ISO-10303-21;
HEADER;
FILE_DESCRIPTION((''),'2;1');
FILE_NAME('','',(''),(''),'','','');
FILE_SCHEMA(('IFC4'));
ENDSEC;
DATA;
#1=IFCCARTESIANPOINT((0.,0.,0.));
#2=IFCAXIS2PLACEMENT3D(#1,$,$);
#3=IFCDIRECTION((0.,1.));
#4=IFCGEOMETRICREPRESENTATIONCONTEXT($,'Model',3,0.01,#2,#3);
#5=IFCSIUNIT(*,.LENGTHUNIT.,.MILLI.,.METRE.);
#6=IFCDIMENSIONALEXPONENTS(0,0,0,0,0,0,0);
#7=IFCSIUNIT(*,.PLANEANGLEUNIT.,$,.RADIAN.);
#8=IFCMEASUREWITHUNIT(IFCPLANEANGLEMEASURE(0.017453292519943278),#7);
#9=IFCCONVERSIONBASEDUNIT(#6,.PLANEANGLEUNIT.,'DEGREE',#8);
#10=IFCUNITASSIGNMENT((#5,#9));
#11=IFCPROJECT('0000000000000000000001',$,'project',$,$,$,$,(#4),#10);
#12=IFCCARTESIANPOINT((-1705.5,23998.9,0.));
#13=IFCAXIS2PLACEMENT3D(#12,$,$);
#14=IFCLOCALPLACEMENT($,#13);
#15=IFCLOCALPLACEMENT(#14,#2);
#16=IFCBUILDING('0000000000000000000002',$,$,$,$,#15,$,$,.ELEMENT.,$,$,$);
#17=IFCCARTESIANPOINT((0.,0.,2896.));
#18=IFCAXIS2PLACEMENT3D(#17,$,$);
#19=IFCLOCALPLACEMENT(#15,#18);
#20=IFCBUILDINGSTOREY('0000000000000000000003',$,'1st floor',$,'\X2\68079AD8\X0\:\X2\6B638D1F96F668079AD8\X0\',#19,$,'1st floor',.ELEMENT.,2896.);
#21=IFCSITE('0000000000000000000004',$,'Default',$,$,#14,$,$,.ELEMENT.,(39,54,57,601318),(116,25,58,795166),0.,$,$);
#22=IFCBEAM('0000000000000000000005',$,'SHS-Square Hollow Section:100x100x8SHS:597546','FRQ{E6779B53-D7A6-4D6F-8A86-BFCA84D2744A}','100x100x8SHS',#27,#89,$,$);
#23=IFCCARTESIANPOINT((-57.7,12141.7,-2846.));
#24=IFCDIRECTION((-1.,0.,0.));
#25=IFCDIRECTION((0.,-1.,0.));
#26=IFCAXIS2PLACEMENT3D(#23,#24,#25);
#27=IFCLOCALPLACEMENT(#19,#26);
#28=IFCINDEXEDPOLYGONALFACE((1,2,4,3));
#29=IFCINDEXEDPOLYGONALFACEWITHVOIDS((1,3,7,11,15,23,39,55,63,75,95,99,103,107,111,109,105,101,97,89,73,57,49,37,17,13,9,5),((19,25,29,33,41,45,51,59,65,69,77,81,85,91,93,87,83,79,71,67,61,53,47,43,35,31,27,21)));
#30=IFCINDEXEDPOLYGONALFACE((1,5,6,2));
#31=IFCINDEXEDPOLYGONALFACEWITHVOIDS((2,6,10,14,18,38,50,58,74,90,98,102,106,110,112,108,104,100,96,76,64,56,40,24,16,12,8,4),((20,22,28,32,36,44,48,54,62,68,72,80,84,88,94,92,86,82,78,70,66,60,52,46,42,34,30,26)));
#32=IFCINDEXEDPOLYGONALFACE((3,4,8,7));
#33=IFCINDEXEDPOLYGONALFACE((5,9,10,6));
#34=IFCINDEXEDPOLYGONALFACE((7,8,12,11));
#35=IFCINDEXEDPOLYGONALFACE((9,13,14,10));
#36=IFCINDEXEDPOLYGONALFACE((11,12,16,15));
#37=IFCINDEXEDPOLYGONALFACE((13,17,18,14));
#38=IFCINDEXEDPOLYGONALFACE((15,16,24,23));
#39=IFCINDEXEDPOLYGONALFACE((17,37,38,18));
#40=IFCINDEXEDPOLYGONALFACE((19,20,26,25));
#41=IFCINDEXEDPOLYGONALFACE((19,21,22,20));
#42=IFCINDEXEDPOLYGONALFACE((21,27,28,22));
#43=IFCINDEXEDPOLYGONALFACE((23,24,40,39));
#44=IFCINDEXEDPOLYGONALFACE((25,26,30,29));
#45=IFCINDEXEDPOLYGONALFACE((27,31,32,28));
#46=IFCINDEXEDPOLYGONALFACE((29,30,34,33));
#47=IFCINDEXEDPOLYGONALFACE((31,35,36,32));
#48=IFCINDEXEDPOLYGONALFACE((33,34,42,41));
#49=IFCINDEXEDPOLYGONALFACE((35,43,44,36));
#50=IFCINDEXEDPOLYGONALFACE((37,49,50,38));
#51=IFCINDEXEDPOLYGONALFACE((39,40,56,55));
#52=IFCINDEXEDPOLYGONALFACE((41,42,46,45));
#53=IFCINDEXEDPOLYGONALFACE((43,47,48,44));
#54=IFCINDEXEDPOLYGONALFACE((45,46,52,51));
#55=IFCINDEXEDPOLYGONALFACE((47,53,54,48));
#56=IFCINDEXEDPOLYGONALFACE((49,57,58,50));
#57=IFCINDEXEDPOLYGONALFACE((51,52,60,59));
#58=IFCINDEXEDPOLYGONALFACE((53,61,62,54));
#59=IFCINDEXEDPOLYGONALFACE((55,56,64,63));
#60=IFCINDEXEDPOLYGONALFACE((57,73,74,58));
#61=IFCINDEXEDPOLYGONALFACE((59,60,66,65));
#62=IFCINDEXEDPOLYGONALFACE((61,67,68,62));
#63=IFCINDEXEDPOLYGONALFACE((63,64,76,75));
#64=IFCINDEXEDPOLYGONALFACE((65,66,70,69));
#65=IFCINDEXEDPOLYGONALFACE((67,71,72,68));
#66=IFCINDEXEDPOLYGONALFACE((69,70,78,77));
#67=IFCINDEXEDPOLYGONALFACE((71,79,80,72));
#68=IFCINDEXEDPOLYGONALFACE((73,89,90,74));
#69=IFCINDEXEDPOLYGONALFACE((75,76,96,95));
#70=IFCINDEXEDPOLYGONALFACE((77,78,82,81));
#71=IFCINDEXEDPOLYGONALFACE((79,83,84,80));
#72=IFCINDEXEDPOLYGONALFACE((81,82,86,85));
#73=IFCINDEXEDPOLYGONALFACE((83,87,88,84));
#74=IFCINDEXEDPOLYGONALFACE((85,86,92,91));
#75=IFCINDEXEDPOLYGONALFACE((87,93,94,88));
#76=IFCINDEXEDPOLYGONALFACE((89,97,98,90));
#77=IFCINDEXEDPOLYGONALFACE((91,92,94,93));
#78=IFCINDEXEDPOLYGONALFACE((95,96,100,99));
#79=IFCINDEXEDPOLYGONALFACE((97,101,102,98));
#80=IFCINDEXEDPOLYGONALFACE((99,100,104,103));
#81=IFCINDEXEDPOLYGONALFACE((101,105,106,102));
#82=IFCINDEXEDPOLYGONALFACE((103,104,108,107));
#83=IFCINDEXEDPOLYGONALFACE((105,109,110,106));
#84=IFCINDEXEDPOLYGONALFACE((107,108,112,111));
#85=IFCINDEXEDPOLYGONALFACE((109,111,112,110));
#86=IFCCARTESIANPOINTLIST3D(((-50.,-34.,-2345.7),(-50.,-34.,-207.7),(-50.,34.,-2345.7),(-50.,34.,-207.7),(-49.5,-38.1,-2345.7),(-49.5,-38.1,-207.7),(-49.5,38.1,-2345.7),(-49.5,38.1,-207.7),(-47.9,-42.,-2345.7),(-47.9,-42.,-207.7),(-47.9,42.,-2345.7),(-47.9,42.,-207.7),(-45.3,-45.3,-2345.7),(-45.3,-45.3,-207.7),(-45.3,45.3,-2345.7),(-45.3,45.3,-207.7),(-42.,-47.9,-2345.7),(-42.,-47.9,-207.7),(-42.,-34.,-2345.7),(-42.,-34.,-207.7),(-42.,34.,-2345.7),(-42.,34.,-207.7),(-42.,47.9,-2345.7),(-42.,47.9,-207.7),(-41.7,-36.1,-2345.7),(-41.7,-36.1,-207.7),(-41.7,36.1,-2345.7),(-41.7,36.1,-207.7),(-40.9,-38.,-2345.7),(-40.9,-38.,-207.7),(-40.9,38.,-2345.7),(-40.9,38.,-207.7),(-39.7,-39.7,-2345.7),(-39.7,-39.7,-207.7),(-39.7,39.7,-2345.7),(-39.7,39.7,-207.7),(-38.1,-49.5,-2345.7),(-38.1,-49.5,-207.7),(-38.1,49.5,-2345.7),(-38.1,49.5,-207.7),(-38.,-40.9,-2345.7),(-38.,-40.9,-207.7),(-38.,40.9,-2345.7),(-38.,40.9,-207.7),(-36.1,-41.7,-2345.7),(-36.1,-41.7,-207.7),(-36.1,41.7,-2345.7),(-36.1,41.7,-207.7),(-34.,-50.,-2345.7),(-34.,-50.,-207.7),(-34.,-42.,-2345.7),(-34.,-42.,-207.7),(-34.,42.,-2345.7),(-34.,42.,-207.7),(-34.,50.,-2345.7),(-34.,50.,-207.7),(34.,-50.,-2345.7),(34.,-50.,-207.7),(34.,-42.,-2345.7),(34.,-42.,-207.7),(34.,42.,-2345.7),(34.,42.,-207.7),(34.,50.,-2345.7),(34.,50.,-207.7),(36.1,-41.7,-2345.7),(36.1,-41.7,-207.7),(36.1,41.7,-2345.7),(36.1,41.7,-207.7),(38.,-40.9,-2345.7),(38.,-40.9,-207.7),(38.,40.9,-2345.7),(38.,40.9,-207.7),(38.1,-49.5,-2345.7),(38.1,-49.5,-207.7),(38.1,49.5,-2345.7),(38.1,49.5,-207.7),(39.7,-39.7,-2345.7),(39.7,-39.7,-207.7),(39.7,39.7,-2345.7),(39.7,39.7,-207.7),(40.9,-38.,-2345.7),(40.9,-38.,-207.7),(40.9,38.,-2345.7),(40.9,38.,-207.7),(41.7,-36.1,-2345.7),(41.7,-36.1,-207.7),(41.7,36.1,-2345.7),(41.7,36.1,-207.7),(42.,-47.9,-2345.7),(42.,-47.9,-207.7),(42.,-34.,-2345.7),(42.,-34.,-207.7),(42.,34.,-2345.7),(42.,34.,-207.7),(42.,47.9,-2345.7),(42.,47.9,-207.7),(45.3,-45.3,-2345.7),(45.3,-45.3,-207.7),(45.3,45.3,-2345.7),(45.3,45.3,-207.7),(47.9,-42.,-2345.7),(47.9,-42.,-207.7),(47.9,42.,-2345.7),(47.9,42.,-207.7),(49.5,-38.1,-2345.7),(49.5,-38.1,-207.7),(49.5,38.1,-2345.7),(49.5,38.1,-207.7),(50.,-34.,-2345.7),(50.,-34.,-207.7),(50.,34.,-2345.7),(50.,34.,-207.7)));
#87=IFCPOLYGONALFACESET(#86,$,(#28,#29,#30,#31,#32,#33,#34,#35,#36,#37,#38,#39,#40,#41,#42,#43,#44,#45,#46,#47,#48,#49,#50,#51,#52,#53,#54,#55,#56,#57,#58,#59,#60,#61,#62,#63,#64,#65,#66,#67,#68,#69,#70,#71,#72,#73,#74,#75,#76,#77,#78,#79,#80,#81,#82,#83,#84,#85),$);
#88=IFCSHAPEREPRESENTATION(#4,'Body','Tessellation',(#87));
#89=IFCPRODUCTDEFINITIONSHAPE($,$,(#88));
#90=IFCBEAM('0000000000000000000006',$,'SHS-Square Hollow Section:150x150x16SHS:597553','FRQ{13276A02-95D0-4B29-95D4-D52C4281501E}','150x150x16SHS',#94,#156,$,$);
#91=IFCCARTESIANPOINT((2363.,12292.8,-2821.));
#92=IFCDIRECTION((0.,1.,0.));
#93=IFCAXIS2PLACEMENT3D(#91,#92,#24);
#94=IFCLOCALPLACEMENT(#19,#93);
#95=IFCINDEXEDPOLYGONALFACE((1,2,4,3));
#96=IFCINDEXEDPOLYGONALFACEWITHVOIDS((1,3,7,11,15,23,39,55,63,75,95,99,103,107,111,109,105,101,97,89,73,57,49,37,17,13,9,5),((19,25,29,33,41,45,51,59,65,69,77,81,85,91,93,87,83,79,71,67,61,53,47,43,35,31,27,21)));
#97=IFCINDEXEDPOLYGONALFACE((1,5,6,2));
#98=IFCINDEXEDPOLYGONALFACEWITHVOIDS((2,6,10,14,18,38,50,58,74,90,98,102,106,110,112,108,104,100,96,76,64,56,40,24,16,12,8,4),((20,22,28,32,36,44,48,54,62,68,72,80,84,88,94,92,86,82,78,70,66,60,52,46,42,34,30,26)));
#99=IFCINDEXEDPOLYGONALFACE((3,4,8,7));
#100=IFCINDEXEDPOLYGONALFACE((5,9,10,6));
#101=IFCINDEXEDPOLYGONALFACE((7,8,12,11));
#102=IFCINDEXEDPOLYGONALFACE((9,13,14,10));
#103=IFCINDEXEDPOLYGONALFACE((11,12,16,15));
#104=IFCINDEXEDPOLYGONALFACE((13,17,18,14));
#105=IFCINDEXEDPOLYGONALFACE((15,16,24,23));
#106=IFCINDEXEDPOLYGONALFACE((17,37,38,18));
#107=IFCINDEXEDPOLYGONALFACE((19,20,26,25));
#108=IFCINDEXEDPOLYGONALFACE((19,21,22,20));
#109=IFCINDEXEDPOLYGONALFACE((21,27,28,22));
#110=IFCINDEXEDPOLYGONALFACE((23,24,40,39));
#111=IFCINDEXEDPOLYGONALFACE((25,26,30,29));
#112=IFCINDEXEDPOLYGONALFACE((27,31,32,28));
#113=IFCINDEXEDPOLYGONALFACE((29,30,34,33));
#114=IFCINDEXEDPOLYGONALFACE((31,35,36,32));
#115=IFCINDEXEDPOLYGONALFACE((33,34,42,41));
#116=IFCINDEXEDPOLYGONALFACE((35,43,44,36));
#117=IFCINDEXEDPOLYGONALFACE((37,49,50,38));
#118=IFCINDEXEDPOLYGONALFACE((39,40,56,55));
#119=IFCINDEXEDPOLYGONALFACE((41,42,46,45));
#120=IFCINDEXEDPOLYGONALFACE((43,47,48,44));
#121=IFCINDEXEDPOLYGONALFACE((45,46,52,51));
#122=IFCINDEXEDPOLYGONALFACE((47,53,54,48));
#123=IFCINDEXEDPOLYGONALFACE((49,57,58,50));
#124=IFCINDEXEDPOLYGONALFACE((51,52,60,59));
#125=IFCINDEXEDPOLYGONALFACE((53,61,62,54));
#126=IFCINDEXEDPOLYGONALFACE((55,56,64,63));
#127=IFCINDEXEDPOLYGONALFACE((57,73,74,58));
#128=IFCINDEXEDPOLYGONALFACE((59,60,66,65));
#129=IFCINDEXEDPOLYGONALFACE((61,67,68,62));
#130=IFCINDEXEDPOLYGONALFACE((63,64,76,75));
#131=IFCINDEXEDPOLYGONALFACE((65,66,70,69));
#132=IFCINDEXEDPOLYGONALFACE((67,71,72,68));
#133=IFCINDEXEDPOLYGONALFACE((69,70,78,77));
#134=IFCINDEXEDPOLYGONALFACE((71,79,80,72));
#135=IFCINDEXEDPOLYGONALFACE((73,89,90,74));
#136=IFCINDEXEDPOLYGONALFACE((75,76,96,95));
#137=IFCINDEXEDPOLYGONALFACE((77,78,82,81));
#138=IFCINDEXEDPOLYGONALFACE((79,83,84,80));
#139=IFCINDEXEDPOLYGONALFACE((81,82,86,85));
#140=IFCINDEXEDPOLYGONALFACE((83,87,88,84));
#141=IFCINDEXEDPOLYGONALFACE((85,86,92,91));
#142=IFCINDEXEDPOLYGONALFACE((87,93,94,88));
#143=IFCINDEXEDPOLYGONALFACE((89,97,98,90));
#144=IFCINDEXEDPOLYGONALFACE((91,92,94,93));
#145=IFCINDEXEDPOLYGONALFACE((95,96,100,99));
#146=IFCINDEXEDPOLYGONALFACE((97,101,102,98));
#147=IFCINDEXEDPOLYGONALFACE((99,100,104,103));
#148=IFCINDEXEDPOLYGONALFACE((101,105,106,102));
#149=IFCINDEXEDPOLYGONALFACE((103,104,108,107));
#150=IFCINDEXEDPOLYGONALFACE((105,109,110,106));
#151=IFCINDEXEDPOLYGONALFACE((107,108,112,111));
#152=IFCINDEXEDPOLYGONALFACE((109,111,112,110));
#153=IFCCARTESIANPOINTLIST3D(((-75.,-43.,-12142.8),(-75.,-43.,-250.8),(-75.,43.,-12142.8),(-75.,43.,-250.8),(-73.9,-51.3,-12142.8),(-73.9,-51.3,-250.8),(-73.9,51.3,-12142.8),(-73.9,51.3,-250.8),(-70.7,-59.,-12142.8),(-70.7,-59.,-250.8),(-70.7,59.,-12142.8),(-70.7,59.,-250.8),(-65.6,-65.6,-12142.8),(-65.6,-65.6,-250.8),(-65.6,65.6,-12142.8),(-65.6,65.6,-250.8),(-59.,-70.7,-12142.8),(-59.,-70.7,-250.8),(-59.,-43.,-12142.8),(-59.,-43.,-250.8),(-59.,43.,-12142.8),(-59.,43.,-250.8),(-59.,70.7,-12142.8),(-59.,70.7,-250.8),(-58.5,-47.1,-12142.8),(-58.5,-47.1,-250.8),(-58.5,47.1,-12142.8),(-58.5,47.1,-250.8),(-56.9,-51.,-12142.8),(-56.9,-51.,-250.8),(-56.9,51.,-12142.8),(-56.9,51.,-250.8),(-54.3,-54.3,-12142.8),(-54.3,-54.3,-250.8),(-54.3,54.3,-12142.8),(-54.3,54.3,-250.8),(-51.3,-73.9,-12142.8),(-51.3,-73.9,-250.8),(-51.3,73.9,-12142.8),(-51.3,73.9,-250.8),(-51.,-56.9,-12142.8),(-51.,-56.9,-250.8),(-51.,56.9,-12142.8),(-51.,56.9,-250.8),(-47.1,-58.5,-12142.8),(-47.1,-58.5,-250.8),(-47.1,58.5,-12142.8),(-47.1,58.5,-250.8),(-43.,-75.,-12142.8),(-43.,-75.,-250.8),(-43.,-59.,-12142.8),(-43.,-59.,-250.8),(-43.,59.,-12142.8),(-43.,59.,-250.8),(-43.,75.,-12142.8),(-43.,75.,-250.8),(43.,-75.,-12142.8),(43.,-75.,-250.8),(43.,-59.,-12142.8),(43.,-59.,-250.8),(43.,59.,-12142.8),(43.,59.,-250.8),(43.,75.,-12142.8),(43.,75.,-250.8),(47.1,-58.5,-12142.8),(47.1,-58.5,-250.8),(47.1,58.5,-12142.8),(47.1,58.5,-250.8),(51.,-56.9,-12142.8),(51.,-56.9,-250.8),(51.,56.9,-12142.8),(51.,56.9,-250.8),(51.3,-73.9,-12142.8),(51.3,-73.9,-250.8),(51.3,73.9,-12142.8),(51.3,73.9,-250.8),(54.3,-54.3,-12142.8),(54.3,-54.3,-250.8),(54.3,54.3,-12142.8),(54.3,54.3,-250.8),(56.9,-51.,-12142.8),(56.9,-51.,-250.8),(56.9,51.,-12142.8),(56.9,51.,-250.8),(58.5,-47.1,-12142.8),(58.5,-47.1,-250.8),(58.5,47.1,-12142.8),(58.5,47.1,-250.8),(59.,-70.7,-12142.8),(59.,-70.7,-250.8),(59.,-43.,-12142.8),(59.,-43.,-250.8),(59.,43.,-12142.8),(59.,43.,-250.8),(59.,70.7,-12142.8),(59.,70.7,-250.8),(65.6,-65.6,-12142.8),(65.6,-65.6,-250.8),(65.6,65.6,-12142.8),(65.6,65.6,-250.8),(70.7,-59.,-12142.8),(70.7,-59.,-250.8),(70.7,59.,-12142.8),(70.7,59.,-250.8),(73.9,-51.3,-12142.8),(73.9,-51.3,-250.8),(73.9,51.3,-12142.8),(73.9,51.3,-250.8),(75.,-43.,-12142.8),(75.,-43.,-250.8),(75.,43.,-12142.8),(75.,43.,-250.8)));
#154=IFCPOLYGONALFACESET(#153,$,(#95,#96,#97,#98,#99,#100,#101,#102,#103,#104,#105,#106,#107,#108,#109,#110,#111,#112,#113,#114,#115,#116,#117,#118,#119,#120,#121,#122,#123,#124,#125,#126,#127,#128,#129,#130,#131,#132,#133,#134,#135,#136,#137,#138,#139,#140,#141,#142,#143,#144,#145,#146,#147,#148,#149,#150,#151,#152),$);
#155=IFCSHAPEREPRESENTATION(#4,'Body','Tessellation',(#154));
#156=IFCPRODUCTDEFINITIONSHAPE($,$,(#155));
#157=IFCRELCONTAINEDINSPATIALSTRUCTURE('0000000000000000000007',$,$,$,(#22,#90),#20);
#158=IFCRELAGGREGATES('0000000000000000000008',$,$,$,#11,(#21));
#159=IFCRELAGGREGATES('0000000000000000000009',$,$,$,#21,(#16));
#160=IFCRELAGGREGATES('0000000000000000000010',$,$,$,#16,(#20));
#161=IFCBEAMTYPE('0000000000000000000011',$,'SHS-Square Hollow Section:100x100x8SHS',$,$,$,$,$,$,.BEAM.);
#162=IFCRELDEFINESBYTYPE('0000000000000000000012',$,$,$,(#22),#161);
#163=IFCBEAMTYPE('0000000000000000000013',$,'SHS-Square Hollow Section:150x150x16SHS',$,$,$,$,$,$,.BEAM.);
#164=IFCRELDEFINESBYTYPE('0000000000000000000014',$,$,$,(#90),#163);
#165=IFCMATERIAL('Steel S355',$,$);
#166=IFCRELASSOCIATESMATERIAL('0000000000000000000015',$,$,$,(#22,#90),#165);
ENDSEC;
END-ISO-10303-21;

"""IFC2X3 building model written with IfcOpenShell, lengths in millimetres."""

from ifc_helpers import new_model, entity, si_unit, converted_unit, direction, frame, origin, origin_2d, place, context, project, spatial, hollow_rectangle, extrude, clip, halfspace, material, type_object, element, save


model = new_model("IFC2X3")

# Units and contexts
model_context = context("Model", 3, precision=0.01, world=origin(), true_north=direction((0.0, 1.0)))
ifc_project = project(units=[si_unit("LENGTHUNIT", "METRE", prefix="MILLI"), converted_unit("PLANEANGLEUNIT", "DEGREE", entity("IfcPlaneAngleMeasure", 0.017453292519943278), si_unit("PLANEANGLEUNIT", "RADIAN"), dimensions=[0, 0, 0, 0, 0, 0, 0])], contexts=[model_context])

# Site, building, storey
site_placement = place(None, frame((-1705.5, 23998.9, 0.0)))
site = spatial("IfcSite", under=ifc_project, at=site_placement, Name="Default", CompositionType="ELEMENT", RefLatitude=(39, 54, 57, 601318), RefLongitude=(116, 25, 58, 795166), RefElevation=0.0)
building_placement = place(site_placement, origin())
building = spatial("IfcBuilding", under=site, at=building_placement, CompositionType="ELEMENT")
storey_placement = place(building_placement, frame((0.0, 0.0, 2896.0)))
storey = spatial("IfcBuildingStorey", under=building, at=storey_placement, Name="1st floor", ObjectType="标高:正负零标高", LongName="1st floor", CompositionType="ELEMENT", Elevation=2896.0)

# Shared definitions
ifc_material_1 = material(Name="Steel S355")

# Beams
beam_type_1 = type_object("IfcBeamType", Name="SHS-Square Hollow Section:100x100x8SHS", PredefinedType="BEAM")
beam_1_placement = place(storey_placement, frame((-57.7, 12141.7, -2846.0), z_axis=(-1.0, 0.0, 0.0), x_axis=(0.0, -1.0, 0.0)))
element("IfcBeam", 1, at=beam_1_placement, inside=storey, type_object=beam_type_1, material=ifc_material_1, Name="SHS-Square Hollow Section:100x100x8SHS:597546", Description="FRQ{E6779B53-D7A6-4D6F-8A86-BFCA84D2744A}", ObjectType="100x100x8SHS", context=model_context, shape_type="Clipping", body=[
    clip(clip(extrude(hollow_rectangle(XDim=100.0, YDim=100.0, WallThickness=8.0, InnerFilletRadius=8.0, OuterFilletRadius=16.0, at=origin_2d()), origin(), (0.0, 0.0, -1.0), 2551.4), halfspace(frame((12141.7, -50.0, -207.7), z_axis=(0.0, 0.0, -1.0), x_axis=(-1.0, 0.0, 0.0)), True)), halfspace(frame((12141.7, -50.0, -2345.7), z_axis=(0.0, 0.0, 1.0), x_axis=(1.0, 0.0, 0.0)), True)),
])
beam_type_2 = type_object("IfcBeamType", Name="SHS-Square Hollow Section:150x150x16SHS", PredefinedType="BEAM")
beam_2_placement = place(storey_placement, frame((2363.0, 12292.8, -2821.0), z_axis=(0.0, 1.0, 0.0), x_axis=(-1.0, 0.0, 0.0)))
element("IfcBeam", 2, at=beam_2_placement, inside=storey, type_object=beam_type_2, material=ifc_material_1, Name="SHS-Square Hollow Section:150x150x16SHS:597553", Description="FRQ{13276A02-95D0-4B29-95D4-D52C4281501E}", ObjectType="150x150x16SHS", context=model_context, shape_type="Clipping", body=[
    clip(clip(extrude(hollow_rectangle(XDim=150.0, YDim=150.0, WallThickness=16.0, InnerFilletRadius=16.0, OuterFilletRadius=32.0, at=origin_2d()), origin(), (0.0, 0.0, -1.0), 12398.9), halfspace(frame((2363.0, -75.0, -12142.8), z_axis=(0.0, 0.0, 1.0), x_axis=(1.0, 0.0, 0.0)), True)), halfspace(frame((2363.0, -75.0, -250.8), z_axis=(0.0, 0.0, -1.0), x_axis=(-1.0, 0.0, 0.0)), True)),
])

save(model, "model.ifc")
